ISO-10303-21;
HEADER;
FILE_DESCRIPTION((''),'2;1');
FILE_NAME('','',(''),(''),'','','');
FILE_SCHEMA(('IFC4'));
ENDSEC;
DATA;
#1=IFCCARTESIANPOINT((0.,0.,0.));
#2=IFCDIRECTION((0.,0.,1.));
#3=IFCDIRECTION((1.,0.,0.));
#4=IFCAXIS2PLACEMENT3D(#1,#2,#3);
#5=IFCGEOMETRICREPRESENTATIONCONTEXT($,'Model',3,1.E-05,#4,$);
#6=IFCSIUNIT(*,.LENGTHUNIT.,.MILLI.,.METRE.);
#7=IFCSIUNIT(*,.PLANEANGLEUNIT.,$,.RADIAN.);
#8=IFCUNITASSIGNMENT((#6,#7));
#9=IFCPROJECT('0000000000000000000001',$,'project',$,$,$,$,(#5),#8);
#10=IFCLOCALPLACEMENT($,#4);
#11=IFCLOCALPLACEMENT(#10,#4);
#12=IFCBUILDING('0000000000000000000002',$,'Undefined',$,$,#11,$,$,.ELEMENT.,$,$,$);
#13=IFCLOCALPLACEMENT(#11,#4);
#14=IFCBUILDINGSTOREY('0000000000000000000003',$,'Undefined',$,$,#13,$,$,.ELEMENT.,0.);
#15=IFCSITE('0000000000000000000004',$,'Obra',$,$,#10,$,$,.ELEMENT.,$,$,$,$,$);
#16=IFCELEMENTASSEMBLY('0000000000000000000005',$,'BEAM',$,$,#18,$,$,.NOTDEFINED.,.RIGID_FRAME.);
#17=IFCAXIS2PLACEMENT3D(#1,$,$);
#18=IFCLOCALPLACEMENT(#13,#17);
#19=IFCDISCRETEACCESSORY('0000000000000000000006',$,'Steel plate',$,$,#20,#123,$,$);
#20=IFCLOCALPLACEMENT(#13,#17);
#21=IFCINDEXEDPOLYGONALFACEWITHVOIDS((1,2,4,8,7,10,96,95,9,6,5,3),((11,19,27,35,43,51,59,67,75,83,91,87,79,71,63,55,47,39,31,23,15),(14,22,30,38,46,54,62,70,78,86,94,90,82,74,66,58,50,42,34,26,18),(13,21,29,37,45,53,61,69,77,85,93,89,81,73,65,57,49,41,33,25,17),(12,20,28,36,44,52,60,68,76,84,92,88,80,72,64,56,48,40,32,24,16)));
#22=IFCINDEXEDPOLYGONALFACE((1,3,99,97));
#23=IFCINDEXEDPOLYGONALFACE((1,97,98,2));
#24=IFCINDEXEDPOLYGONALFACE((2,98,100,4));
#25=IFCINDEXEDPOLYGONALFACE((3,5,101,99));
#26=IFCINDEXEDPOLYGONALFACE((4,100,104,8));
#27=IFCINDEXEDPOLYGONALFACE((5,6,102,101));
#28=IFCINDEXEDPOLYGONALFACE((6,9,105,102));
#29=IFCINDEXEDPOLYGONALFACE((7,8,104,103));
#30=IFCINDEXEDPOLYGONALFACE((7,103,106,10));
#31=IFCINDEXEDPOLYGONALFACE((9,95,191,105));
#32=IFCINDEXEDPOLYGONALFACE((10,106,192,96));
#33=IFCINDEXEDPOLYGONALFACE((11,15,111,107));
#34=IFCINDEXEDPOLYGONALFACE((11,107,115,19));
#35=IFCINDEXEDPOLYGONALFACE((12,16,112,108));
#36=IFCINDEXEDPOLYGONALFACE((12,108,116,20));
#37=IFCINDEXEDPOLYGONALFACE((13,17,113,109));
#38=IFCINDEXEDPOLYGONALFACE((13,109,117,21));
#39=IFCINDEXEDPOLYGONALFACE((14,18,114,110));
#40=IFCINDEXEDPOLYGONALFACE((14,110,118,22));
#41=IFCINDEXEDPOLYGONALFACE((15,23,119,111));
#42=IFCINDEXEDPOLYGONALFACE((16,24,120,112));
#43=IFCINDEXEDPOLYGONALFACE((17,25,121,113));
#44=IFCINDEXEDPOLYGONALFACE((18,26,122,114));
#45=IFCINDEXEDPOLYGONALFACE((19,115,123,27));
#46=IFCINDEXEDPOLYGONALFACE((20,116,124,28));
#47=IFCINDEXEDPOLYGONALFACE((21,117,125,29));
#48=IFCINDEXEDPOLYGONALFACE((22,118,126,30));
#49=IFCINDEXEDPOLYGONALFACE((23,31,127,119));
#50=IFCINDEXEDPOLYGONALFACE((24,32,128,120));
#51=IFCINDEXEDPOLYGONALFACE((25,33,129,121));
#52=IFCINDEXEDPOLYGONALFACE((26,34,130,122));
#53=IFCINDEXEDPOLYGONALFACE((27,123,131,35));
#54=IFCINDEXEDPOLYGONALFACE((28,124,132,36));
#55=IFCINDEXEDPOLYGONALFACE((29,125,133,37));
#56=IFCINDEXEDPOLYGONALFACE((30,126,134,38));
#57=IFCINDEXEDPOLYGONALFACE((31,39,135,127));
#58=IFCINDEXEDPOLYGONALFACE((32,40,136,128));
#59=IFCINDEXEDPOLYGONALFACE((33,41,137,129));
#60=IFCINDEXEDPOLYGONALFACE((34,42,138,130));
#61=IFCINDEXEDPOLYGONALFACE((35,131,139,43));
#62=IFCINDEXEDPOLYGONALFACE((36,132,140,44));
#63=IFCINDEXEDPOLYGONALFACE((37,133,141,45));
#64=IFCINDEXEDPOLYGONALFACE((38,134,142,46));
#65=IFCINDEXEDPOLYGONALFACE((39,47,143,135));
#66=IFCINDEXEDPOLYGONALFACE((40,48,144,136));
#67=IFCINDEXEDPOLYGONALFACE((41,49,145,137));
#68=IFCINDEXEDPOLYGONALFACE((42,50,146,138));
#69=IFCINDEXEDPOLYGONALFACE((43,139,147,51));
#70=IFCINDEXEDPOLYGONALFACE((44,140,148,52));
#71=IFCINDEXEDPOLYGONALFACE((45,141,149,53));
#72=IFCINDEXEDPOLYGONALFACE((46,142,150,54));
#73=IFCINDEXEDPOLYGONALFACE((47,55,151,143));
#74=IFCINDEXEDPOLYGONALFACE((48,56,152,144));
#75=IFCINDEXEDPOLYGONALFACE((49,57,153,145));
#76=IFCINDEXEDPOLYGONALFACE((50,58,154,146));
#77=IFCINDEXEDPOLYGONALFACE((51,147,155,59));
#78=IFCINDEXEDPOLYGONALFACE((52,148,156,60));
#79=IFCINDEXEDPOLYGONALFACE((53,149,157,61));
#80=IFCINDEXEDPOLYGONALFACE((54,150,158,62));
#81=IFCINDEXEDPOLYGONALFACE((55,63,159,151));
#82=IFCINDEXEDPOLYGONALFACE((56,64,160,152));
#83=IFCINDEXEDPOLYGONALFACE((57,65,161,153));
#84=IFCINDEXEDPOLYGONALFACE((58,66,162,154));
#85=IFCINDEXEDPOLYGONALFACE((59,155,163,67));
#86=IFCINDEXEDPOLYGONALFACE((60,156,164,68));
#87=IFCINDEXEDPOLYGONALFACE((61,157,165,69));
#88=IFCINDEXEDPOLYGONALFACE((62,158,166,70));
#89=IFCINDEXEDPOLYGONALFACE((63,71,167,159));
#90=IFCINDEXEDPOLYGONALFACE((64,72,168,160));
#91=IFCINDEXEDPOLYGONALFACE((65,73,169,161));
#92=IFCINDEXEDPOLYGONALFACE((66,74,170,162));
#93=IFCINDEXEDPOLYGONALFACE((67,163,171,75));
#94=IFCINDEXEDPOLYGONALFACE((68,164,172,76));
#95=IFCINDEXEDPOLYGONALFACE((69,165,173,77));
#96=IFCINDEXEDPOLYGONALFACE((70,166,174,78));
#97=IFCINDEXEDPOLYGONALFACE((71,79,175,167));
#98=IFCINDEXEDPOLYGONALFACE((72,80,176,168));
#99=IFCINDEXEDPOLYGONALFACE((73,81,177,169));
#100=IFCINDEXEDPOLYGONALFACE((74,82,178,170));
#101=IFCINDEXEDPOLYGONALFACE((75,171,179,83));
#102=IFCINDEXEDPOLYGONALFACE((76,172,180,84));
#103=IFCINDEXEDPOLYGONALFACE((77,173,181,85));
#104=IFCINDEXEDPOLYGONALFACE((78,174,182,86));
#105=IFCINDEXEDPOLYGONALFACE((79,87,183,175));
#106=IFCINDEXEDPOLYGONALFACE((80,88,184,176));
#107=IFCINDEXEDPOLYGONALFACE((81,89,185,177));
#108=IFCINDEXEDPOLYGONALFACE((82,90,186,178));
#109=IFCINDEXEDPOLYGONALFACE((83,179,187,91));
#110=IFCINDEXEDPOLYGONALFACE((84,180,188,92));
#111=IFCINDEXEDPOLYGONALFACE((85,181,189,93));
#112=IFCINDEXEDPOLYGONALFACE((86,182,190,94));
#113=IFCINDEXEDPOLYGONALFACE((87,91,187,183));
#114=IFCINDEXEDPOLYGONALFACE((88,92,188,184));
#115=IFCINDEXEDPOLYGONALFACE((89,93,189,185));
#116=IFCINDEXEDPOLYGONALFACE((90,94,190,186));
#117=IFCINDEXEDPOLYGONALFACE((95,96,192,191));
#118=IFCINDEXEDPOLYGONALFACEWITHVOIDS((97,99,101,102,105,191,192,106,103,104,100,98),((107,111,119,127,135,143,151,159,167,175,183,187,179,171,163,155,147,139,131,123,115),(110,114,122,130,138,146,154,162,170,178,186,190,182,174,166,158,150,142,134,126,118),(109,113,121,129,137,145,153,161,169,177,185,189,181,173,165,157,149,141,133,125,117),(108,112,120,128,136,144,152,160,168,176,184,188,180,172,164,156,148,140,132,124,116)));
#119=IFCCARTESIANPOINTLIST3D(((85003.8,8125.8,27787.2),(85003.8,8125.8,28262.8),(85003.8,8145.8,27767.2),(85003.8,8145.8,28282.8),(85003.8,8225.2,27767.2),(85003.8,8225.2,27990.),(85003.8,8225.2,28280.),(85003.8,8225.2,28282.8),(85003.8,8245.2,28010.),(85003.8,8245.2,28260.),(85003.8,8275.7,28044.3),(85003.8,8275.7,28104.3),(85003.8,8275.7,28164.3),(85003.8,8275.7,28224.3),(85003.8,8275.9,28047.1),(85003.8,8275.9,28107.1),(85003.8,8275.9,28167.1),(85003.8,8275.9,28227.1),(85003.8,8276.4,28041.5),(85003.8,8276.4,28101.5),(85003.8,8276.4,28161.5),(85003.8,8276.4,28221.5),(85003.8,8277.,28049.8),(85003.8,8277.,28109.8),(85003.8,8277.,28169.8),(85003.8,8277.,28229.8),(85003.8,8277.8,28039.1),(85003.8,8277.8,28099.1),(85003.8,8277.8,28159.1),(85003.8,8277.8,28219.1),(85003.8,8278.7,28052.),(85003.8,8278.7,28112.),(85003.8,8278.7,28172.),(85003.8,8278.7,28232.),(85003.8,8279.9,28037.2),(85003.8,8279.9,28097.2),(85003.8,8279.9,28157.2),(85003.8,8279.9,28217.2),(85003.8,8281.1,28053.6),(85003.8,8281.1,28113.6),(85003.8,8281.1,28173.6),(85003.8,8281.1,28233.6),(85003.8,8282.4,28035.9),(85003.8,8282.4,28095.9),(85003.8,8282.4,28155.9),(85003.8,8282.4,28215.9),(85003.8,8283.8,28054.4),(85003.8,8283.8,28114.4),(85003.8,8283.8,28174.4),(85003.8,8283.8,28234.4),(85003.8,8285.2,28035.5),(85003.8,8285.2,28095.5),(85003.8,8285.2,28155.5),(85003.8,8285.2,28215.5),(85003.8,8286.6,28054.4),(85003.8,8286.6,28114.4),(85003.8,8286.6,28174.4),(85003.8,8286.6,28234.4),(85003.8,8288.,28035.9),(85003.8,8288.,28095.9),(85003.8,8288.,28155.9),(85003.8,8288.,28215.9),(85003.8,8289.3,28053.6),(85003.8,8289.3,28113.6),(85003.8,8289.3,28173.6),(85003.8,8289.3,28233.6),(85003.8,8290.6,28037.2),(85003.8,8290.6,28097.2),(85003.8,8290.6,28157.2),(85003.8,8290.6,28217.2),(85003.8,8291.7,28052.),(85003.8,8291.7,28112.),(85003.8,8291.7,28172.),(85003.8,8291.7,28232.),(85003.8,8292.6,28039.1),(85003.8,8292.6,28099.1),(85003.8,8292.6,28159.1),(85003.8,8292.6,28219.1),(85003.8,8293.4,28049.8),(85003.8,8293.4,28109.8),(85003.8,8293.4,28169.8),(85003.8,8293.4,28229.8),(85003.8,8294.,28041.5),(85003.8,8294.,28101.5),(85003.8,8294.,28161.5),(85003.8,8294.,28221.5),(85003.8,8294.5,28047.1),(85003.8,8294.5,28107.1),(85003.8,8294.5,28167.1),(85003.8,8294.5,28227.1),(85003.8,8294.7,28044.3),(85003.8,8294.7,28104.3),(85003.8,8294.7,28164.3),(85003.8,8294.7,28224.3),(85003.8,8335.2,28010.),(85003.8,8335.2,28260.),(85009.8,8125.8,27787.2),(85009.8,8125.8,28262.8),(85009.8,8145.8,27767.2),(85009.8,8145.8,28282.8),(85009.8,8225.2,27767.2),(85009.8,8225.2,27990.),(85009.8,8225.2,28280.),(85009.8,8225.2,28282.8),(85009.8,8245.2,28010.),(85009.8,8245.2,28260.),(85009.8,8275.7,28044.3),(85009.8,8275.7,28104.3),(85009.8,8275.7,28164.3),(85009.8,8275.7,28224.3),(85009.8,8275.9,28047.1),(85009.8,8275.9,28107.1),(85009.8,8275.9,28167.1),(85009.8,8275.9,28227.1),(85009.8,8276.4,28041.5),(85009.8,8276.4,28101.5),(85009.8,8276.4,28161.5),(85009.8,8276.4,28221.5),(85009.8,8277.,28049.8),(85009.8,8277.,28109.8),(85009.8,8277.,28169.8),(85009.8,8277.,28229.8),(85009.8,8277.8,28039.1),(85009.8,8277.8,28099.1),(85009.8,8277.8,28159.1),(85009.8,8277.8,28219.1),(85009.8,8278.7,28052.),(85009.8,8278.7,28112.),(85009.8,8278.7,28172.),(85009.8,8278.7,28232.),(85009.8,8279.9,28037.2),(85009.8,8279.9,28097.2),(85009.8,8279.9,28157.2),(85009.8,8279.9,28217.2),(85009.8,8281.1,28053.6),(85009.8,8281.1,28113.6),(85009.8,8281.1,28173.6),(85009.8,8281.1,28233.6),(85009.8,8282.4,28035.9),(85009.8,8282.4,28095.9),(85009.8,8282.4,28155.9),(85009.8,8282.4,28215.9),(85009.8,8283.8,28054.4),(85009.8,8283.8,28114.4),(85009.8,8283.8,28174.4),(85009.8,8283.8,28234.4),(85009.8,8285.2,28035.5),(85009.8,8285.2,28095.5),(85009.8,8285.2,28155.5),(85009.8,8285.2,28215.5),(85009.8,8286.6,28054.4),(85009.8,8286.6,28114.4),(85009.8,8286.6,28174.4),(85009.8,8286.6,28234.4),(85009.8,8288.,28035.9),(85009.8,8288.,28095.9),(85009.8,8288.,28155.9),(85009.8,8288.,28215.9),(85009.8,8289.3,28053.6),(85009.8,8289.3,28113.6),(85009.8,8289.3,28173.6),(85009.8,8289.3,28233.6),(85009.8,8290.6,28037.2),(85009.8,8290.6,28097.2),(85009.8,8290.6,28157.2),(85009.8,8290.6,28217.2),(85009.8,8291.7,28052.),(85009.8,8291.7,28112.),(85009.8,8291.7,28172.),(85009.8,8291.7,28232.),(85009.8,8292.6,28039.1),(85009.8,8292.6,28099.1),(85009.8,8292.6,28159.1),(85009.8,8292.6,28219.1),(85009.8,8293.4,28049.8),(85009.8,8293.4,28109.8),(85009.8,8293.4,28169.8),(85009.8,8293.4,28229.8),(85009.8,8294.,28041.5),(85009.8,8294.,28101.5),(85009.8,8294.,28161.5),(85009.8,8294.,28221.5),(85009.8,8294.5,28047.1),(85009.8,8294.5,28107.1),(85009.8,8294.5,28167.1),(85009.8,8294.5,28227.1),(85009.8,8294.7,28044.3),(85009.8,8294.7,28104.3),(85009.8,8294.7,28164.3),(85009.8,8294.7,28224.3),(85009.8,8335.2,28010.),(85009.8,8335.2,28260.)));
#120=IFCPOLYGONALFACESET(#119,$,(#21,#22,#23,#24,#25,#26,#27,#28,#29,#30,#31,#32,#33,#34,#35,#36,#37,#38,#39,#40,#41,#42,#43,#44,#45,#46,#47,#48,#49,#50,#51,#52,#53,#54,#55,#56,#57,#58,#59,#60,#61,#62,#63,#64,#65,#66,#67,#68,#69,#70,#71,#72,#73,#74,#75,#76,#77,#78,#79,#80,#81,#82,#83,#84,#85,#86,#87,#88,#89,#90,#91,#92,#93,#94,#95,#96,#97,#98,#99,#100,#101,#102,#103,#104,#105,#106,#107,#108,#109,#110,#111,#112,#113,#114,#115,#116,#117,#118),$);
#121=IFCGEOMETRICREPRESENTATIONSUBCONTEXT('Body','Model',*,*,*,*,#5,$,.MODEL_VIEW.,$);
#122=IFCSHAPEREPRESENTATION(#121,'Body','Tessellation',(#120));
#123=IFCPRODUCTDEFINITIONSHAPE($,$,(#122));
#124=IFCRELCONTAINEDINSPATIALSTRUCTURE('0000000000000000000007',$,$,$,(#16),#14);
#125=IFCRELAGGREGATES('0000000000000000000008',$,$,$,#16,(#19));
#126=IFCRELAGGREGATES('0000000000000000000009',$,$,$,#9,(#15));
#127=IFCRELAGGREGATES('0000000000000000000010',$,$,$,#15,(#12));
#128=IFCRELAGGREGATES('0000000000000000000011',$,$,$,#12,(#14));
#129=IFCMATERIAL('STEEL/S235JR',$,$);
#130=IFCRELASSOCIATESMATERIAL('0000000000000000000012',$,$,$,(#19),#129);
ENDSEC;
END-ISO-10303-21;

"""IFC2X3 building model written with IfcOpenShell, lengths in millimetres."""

from ifc_helpers import new_model, si_unit, frame, origin_with_axes, origin_2d_with_axis, place, context, subcontext, project, spatial, polyline, circle, outline, extrude, source, transform, mapped, material, element, aggregate, save


model = new_model("IFC2X3")

# Units and contexts
model_context = context("Model", 3, precision=1e-05, world=origin_with_axes())
body_context = subcontext(model_context, "Body", "Model", "MODEL_VIEW")
ifc_project = project(units=[si_unit("LENGTHUNIT", "METRE", prefix="MILLI"), si_unit("PLANEANGLEUNIT", "RADIAN")], contexts=[model_context])

# Site, building, storey
site_placement = place(None, origin_with_axes())
site = spatial("IfcSite", under=ifc_project, at=site_placement, Name="Obra", CompositionType="ELEMENT")
building_placement = place(site_placement, origin_with_axes())
building = spatial("IfcBuilding", under=site, at=building_placement, Name="Undefined", CompositionType="ELEMENT")
storey_placement = place(building_placement, origin_with_axes())
storey = spatial("IfcBuildingStorey", under=building, at=storey_placement, Name="Undefined", CompositionType="ELEMENT", Elevation=0.0)

# Shared definitions
ifc_material = material(Name="STEEL/S235JR")

# Element assembly, discrete accessory, opening
assembly_1_placement = place(storey_placement, origin_with_axes())
assembly_1 = element("IfcElementAssembly", 1, at=assembly_1_placement, inside=storey, Name="BEAM", AssemblyPlace="NOTDEFINED", PredefinedType="RIGID_FRAME")
discrete_accessory_1_placement = place(assembly_1_placement, frame((85006.8, 8125.8, 27787.2), z_axis=(1.0, -0.000001, 0.0), x_axis=(0.000001, 0.707107, -0.707107)))
discrete_accessory_1 = element("IfcDiscreteAccessory", 2, at=discrete_accessory_1_placement, material=ifc_material, Name="Steel plate", context=body_context, shape_type="SweptSolid", body=[
    extrude(outline(polyline([(0.0, 0.0), (28.3, 0.0), (84.5, 56.2), (-73.1, 213.7), (-73.1, 242.0), (-9.4, 305.6), (-186.2, 482.4), (-249.9, 418.8), (-278.1, 418.8), (-280.1, 420.8), (-336.3, 364.6), (-336.3, 336.3), (0.0, 0.0)])), frame((0.0, 0.0, -3.0), z_axis=(0.0, 0.0, 1.0), x_axis=(1.0, 0.0, 0.0)), (0.0, 0.0, 1.0), 6.0),
])
shared_shape_1 = source(origin_with_axes(), body_context, "Body", "SweptSolid", [
    extrude(circle(Radius=9.5, at=origin_2d_with_axis()), frame((0.0, -9.8, 0.0), z_axis=(0.0, 1.0, 0.0), x_axis=(1.0, 0.0, 0.0)), (0.0, 0.0, 1.0), 6.2),
])
opening_1_placement = place(assembly_1_placement, frame((85000.0, 8235.2, 28260.0), z_axis=(0.000001, 1.0, 0.0), x_axis=(0.0, 0.0, -1.0)))
element("IfcOpeningElement", 3, at=opening_1_placement, cuts=discrete_accessory_1, ObjectType="Opening", context=body_context, shape_type="MappedRepresentation", body=[
    mapped(shared_shape_1, transform((35.0, 0.0, 50.0))),
    mapped(shared_shape_1, transform((95.0, 0.0, 50.0))),
    mapped(shared_shape_1, transform((155.0, 0.0, 50.0))),
    mapped(shared_shape_1, transform((215.0, 0.0, 50.0))),
])
aggregate(assembly_1, [discrete_accessory_1])

save(model, "model.ifc")
